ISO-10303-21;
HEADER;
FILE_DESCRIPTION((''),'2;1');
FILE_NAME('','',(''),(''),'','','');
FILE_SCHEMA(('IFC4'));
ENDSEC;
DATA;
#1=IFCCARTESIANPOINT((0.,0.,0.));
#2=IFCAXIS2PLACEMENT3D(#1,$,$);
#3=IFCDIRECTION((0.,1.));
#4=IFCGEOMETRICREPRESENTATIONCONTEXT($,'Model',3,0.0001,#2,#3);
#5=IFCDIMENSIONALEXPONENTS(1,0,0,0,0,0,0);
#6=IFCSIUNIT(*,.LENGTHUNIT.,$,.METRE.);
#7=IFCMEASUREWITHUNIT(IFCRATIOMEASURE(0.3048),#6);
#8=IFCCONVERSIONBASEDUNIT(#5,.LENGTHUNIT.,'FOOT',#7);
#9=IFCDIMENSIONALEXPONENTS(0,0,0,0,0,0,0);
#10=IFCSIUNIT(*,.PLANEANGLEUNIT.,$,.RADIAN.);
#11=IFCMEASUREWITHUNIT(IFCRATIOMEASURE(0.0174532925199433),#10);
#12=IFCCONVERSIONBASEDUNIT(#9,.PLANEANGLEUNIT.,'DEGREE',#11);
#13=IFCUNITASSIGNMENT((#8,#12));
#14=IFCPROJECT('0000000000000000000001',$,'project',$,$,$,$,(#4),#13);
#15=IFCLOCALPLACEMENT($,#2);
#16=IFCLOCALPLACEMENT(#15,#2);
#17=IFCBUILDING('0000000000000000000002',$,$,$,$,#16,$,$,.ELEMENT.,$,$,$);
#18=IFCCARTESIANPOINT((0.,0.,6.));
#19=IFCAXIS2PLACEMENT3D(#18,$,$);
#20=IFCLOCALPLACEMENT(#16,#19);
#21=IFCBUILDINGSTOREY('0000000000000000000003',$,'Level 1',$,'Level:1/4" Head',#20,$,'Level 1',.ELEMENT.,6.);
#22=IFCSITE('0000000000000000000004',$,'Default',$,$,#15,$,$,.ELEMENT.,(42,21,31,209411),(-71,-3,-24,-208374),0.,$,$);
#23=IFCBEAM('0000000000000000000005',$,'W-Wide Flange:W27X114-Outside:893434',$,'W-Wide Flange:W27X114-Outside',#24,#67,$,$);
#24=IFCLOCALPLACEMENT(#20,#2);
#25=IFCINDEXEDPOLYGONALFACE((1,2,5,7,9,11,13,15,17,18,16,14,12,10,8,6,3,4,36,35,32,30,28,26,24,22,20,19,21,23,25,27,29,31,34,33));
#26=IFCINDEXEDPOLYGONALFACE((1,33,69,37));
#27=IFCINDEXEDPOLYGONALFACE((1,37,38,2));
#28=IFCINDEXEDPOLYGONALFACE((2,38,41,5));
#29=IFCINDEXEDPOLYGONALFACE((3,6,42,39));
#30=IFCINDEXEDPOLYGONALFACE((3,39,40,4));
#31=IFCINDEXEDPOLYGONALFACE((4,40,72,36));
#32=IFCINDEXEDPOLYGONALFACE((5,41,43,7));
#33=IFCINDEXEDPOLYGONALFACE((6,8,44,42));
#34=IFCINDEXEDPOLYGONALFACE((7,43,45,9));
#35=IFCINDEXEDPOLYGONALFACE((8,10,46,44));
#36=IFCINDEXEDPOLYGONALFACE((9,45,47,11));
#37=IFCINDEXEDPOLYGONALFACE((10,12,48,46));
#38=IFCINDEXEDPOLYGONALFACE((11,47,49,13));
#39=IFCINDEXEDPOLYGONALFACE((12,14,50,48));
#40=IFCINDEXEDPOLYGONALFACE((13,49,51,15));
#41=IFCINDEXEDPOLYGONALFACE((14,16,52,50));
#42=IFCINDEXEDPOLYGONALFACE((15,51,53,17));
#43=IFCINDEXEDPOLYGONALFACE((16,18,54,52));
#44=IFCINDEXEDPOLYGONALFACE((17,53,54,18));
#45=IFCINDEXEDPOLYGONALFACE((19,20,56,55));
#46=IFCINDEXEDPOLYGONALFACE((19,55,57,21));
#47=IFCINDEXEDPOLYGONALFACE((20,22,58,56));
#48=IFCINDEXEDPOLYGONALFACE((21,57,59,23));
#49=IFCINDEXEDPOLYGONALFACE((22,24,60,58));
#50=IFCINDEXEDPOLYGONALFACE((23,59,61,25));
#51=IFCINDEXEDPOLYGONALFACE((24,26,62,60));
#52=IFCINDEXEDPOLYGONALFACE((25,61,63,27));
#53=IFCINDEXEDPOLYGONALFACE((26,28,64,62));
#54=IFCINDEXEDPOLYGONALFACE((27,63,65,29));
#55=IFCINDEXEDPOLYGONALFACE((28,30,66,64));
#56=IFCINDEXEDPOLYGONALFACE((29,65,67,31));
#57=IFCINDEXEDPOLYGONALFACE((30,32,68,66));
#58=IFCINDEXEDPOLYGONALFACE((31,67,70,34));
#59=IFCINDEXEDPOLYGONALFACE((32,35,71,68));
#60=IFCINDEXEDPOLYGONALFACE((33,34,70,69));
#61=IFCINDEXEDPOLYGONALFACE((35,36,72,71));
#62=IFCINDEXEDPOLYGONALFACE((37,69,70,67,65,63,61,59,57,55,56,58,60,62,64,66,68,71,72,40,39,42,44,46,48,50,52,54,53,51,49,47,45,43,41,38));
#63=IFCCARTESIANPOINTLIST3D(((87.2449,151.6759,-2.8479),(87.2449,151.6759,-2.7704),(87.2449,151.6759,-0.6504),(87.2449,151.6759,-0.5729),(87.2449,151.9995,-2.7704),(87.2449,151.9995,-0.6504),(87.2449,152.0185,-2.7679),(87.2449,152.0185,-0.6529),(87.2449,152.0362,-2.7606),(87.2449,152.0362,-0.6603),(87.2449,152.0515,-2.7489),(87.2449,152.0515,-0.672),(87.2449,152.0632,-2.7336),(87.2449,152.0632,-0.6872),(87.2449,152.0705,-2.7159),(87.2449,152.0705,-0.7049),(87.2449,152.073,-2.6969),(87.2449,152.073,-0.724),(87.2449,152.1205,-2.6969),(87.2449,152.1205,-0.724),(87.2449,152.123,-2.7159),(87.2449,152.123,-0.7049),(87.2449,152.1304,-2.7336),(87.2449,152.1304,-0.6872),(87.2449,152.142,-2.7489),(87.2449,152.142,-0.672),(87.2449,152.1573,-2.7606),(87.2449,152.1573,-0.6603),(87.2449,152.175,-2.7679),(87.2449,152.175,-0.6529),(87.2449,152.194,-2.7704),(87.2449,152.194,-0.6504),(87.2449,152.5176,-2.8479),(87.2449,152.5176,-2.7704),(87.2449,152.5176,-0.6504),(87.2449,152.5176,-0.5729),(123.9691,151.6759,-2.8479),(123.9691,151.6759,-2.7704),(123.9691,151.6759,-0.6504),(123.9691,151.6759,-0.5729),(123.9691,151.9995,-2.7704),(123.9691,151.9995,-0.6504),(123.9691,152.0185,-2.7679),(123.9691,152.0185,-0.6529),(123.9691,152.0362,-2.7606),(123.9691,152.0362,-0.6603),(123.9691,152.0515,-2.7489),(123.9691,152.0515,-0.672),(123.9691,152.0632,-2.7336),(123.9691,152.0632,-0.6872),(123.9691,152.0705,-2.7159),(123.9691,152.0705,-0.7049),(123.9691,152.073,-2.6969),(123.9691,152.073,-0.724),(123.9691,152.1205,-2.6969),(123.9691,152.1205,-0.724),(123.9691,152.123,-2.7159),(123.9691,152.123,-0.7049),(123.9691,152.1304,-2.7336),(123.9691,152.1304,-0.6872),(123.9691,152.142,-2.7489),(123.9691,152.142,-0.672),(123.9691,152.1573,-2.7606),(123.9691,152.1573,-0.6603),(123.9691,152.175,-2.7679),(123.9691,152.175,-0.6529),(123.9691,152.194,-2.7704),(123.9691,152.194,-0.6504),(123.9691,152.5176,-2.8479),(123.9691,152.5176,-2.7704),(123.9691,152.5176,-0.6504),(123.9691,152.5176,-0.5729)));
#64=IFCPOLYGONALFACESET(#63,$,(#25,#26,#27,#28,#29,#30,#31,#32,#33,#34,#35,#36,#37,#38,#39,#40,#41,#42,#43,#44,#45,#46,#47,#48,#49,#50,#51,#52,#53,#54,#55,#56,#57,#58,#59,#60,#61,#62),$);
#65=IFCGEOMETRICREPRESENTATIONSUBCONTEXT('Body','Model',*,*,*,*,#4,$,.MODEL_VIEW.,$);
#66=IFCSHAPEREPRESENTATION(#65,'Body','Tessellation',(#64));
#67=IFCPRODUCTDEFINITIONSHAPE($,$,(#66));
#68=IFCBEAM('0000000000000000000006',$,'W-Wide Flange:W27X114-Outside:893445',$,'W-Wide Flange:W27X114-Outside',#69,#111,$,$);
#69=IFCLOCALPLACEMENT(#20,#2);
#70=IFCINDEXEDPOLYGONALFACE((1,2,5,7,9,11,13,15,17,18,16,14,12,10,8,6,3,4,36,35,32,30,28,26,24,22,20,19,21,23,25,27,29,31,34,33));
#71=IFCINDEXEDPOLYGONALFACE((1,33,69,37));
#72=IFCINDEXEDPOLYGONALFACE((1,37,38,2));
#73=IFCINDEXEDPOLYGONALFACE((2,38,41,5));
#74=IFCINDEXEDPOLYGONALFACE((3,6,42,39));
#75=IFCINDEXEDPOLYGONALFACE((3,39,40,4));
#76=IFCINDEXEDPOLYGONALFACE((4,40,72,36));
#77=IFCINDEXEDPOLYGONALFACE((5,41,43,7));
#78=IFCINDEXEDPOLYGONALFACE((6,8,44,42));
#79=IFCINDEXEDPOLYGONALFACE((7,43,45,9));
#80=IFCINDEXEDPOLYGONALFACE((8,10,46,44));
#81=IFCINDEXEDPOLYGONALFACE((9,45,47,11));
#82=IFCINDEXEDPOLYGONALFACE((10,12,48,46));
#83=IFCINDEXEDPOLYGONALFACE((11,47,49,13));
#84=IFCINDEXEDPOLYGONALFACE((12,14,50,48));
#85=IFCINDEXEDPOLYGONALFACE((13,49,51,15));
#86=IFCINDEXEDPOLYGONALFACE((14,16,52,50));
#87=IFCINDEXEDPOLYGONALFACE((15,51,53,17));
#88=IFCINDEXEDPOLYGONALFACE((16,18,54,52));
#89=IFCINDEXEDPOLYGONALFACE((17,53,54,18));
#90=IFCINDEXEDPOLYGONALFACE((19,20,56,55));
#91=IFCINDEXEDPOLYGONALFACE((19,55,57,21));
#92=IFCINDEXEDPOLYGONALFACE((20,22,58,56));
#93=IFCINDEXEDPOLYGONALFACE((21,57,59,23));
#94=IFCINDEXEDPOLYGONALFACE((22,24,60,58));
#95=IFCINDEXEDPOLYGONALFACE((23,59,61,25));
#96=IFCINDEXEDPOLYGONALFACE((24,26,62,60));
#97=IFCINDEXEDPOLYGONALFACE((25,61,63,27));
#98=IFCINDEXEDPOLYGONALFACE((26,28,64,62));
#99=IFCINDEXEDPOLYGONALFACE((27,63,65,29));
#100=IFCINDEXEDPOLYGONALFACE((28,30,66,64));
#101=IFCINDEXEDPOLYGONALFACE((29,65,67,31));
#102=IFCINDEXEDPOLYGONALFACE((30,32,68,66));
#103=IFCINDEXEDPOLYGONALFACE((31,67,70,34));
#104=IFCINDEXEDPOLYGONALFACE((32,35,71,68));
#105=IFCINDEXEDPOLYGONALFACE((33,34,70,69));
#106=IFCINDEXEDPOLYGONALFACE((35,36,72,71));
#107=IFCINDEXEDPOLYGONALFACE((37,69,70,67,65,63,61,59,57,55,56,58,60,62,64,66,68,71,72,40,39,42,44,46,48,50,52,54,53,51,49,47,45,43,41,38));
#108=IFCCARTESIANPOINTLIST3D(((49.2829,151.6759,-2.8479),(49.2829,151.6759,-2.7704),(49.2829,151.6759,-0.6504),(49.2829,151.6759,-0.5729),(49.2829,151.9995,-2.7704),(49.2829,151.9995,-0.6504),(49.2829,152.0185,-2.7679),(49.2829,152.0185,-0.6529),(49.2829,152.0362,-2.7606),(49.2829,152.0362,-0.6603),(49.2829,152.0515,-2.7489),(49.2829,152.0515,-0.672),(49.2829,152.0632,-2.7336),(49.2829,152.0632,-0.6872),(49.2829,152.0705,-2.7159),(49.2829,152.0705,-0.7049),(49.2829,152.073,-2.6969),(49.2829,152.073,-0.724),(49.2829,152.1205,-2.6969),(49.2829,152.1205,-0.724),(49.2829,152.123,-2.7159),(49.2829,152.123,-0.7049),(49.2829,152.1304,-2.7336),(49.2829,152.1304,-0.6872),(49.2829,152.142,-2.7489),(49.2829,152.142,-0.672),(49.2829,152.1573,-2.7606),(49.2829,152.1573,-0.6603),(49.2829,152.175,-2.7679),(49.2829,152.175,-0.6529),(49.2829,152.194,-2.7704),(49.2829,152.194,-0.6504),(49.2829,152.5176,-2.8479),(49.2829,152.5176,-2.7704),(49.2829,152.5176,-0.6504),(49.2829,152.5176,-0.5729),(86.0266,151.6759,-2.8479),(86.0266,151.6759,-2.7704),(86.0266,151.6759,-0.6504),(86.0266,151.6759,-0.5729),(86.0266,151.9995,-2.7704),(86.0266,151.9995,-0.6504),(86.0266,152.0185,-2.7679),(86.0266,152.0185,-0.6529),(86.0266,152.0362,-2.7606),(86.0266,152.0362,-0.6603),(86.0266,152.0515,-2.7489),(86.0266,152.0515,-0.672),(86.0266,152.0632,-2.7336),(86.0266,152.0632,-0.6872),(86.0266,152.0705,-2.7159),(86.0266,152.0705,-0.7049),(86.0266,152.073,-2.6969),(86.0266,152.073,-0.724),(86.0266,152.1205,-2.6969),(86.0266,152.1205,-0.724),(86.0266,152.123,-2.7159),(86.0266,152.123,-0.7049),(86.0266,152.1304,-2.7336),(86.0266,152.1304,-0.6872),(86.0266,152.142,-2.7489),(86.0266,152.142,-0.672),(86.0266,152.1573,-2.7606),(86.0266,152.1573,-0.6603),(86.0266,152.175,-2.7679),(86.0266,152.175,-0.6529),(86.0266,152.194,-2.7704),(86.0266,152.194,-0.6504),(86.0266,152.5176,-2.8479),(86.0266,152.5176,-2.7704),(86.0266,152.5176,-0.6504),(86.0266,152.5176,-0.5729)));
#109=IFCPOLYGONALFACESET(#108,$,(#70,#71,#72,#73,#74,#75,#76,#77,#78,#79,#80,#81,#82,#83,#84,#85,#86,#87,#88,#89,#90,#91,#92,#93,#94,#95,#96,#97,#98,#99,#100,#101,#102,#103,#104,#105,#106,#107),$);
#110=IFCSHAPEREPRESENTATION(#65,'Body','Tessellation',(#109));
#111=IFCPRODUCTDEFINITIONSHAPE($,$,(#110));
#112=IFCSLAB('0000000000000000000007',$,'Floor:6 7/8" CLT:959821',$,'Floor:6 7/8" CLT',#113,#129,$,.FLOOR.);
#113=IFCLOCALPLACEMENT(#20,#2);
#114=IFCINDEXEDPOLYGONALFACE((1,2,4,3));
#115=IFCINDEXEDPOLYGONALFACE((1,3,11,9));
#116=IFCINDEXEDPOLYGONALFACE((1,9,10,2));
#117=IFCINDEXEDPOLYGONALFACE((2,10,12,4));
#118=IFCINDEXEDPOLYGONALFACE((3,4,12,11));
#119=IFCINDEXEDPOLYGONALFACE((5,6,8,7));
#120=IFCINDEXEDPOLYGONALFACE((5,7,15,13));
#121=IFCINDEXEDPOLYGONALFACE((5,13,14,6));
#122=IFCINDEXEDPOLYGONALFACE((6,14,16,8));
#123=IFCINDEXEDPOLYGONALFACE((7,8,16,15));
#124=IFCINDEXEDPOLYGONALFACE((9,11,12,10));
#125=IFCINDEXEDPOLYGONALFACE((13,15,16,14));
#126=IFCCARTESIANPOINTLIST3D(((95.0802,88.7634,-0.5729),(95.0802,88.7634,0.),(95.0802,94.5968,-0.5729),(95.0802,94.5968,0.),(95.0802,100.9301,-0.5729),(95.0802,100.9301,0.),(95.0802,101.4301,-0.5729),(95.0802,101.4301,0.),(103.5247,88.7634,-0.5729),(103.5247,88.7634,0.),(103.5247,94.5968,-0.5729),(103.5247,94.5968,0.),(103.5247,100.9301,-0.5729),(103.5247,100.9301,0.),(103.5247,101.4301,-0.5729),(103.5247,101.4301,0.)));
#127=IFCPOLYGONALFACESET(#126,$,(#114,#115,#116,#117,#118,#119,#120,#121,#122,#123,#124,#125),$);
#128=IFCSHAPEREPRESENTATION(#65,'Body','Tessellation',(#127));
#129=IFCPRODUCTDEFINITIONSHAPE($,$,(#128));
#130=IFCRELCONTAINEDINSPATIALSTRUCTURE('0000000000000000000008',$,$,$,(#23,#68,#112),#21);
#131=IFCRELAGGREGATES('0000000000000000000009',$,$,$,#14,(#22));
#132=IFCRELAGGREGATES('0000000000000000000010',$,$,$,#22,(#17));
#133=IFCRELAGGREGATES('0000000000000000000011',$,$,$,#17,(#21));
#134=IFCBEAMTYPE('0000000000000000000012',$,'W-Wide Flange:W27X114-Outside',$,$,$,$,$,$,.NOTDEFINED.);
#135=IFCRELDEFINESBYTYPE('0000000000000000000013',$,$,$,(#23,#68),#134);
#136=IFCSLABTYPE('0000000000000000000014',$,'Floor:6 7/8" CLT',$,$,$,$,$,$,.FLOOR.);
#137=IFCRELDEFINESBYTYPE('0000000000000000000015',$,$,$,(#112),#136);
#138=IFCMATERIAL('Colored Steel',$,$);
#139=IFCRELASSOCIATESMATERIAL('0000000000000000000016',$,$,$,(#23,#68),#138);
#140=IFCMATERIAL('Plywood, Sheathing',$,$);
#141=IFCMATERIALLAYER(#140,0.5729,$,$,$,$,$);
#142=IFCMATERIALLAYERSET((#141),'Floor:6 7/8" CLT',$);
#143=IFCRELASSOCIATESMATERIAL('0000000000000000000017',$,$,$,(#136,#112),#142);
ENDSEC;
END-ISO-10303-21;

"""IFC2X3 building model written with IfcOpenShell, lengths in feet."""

from ifc_helpers import new_model, entity, si_unit, converted_unit, direction, frame, frame_2d, origin, place, context, subcontext, project, spatial, rectangle, i_section, extrude, material, layer, layer_set, layer_usage, type_object, element, save


model = new_model("IFC2X3")

# Units and contexts
model_context = context("Model", 3, precision=0.0001, world=origin(), true_north=direction((0.0, 1.0)))
body_context = subcontext(model_context, "Body", "Model", "MODEL_VIEW")
ifc_project = project(units=[converted_unit("LENGTHUNIT", "FOOT", entity("IfcRatioMeasure", 0.3048), si_unit("LENGTHUNIT", "METRE"), dimensions=[1, 0, 0, 0, 0, 0, 0]), converted_unit("PLANEANGLEUNIT", "DEGREE", entity("IfcRatioMeasure", 0.0174532925199433), si_unit("PLANEANGLEUNIT", "RADIAN"), dimensions=[0, 0, 0, 0, 0, 0, 0])], contexts=[model_context])

# Site, building, storey
site_placement = place(None, origin())
site = spatial("IfcSite", under=ifc_project, at=site_placement, Name="Default", CompositionType="ELEMENT", RefLatitude=(42, 21, 31, 209411), RefLongitude=(-71, -3, -24, -208374), RefElevation=0.0)
building_placement = place(site_placement, origin())
building = spatial("IfcBuilding", under=site, at=building_placement, CompositionType="ELEMENT")
storey_placement = place(building_placement, frame((0.0, 0.0, 6.0)))
storey = spatial("IfcBuildingStorey", under=building, at=storey_placement, Name="Level 1", ObjectType="Level:1/4\" Head", LongName="Level 1", CompositionType="ELEMENT", Elevation=6.0)

# Beams
ifc_material_1 = material(Name="Colored Steel")
beam_type_1 = type_object("IfcBeamType", Name="W-Wide Flange:W27X114-Outside", PredefinedType="NOTDEFINED")
beam_1_placement = place(storey_placement, frame((86.6358, 152.0968, 0.0)))
element("IfcBeam", 1, at=beam_1_placement, inside=storey, type_object=beam_type_1, material=ifc_material_1, Name="W-Wide Flange:W27X114-Outside:893434", ObjectType="W-Wide Flange:W27X114-Outside", context=body_context, shape_type="SweptSolid", body=[
    extrude(i_section(OverallWidth=0.8417, OverallDepth=2.275, WebThickness=0.0475, FlangeThickness=0.0775, FilletRadius=0.0735, at=frame_2d((0.0, 0.0), x_axis=(0.0, 1.0))), frame((0.6092, 0.0, -1.7104), z_axis=(1.0, 0.0, 0.0), x_axis=(0.0, 0.0, -1.0)), (0.0, 0.0, 1.0), 36.7242),
])
beam_2_placement = place(storey_placement, frame((48.6358, 152.0968, 0.0)))
element("IfcBeam", 2, at=beam_2_placement, inside=storey, type_object=beam_type_1, material=ifc_material_1, Name="W-Wide Flange:W27X114-Outside:893445", ObjectType="W-Wide Flange:W27X114-Outside", context=body_context, shape_type="SweptSolid", body=[
    extrude(i_section(OverallWidth=0.8417, OverallDepth=2.275, WebThickness=0.0475, FlangeThickness=0.0775, FilletRadius=0.0735, at=frame_2d((0.0, 0.0), x_axis=(0.0, 1.0))), frame((0.6471, 0.0, -1.7104), z_axis=(1.0, 0.0, 0.0), x_axis=(0.0, 0.0, -1.0)), (0.0, 0.0, 1.0), 36.7437),
])

# Slab, opening
ifc_material_2 = material(Name="Plywood, Sheathing")
ifc_layer = layer(ifc_material_2, 0.5729)
ifc_layer_set = layer_set([ifc_layer], Name="Floor:6 7/8\" CLT")
ifc_layer_usage = layer_usage(ifc_layer_set, "AXIS3", "POSITIVE", 0.0)
slab_type = type_object("IfcSlabType", Name="Floor:6 7/8\" CLT", PredefinedType="FLOOR", material=ifc_layer_set)
slab_placement = place(storey_placement, frame((95.0802, 88.7634, -0.5729)))
slab = element("IfcSlab", 3, at=slab_placement, inside=storey, type_object=slab_type, material=ifc_layer_usage, Name="Floor:6 7/8\" CLT:959821", ObjectType="Floor:6 7/8\" CLT", PredefinedType="FLOOR", context=body_context, shape_type="SweptSolid", body=[
    extrude(rectangle(XDim=12.6667, YDim=8.4444, at=frame_2d((0.0, 0.0), x_axis=(0.0, -1.0))), frame((4.2222, 6.3333, 0.5729), z_axis=(0.0, 0.0, -1.0), x_axis=(-1.0, 0.0, 0.0)), (0.0, 0.0, 1.0), 0.5729),
])
opening_placement = place(storey_placement, frame((95.0802, 88.7634, -0.5729)))
element("IfcOpeningElement", 4, at=opening_placement, cuts=slab, ObjectType="Opening", context=body_context, shape_type="SweptSolid", body=[
    extrude(rectangle(XDim=6.3333, YDim=24.3333, at=frame_2d((-0.0196, 2.6667), x_axis=(0.0, -1.0))), frame((4.2222, 6.3333, 0.5729), z_axis=(0.0, 0.0, -1.0), x_axis=(-1.0, 0.0, 0.0)), (0.0, 0.0, 1.0), 0.5729),
])

save(model, "model.ifc")
